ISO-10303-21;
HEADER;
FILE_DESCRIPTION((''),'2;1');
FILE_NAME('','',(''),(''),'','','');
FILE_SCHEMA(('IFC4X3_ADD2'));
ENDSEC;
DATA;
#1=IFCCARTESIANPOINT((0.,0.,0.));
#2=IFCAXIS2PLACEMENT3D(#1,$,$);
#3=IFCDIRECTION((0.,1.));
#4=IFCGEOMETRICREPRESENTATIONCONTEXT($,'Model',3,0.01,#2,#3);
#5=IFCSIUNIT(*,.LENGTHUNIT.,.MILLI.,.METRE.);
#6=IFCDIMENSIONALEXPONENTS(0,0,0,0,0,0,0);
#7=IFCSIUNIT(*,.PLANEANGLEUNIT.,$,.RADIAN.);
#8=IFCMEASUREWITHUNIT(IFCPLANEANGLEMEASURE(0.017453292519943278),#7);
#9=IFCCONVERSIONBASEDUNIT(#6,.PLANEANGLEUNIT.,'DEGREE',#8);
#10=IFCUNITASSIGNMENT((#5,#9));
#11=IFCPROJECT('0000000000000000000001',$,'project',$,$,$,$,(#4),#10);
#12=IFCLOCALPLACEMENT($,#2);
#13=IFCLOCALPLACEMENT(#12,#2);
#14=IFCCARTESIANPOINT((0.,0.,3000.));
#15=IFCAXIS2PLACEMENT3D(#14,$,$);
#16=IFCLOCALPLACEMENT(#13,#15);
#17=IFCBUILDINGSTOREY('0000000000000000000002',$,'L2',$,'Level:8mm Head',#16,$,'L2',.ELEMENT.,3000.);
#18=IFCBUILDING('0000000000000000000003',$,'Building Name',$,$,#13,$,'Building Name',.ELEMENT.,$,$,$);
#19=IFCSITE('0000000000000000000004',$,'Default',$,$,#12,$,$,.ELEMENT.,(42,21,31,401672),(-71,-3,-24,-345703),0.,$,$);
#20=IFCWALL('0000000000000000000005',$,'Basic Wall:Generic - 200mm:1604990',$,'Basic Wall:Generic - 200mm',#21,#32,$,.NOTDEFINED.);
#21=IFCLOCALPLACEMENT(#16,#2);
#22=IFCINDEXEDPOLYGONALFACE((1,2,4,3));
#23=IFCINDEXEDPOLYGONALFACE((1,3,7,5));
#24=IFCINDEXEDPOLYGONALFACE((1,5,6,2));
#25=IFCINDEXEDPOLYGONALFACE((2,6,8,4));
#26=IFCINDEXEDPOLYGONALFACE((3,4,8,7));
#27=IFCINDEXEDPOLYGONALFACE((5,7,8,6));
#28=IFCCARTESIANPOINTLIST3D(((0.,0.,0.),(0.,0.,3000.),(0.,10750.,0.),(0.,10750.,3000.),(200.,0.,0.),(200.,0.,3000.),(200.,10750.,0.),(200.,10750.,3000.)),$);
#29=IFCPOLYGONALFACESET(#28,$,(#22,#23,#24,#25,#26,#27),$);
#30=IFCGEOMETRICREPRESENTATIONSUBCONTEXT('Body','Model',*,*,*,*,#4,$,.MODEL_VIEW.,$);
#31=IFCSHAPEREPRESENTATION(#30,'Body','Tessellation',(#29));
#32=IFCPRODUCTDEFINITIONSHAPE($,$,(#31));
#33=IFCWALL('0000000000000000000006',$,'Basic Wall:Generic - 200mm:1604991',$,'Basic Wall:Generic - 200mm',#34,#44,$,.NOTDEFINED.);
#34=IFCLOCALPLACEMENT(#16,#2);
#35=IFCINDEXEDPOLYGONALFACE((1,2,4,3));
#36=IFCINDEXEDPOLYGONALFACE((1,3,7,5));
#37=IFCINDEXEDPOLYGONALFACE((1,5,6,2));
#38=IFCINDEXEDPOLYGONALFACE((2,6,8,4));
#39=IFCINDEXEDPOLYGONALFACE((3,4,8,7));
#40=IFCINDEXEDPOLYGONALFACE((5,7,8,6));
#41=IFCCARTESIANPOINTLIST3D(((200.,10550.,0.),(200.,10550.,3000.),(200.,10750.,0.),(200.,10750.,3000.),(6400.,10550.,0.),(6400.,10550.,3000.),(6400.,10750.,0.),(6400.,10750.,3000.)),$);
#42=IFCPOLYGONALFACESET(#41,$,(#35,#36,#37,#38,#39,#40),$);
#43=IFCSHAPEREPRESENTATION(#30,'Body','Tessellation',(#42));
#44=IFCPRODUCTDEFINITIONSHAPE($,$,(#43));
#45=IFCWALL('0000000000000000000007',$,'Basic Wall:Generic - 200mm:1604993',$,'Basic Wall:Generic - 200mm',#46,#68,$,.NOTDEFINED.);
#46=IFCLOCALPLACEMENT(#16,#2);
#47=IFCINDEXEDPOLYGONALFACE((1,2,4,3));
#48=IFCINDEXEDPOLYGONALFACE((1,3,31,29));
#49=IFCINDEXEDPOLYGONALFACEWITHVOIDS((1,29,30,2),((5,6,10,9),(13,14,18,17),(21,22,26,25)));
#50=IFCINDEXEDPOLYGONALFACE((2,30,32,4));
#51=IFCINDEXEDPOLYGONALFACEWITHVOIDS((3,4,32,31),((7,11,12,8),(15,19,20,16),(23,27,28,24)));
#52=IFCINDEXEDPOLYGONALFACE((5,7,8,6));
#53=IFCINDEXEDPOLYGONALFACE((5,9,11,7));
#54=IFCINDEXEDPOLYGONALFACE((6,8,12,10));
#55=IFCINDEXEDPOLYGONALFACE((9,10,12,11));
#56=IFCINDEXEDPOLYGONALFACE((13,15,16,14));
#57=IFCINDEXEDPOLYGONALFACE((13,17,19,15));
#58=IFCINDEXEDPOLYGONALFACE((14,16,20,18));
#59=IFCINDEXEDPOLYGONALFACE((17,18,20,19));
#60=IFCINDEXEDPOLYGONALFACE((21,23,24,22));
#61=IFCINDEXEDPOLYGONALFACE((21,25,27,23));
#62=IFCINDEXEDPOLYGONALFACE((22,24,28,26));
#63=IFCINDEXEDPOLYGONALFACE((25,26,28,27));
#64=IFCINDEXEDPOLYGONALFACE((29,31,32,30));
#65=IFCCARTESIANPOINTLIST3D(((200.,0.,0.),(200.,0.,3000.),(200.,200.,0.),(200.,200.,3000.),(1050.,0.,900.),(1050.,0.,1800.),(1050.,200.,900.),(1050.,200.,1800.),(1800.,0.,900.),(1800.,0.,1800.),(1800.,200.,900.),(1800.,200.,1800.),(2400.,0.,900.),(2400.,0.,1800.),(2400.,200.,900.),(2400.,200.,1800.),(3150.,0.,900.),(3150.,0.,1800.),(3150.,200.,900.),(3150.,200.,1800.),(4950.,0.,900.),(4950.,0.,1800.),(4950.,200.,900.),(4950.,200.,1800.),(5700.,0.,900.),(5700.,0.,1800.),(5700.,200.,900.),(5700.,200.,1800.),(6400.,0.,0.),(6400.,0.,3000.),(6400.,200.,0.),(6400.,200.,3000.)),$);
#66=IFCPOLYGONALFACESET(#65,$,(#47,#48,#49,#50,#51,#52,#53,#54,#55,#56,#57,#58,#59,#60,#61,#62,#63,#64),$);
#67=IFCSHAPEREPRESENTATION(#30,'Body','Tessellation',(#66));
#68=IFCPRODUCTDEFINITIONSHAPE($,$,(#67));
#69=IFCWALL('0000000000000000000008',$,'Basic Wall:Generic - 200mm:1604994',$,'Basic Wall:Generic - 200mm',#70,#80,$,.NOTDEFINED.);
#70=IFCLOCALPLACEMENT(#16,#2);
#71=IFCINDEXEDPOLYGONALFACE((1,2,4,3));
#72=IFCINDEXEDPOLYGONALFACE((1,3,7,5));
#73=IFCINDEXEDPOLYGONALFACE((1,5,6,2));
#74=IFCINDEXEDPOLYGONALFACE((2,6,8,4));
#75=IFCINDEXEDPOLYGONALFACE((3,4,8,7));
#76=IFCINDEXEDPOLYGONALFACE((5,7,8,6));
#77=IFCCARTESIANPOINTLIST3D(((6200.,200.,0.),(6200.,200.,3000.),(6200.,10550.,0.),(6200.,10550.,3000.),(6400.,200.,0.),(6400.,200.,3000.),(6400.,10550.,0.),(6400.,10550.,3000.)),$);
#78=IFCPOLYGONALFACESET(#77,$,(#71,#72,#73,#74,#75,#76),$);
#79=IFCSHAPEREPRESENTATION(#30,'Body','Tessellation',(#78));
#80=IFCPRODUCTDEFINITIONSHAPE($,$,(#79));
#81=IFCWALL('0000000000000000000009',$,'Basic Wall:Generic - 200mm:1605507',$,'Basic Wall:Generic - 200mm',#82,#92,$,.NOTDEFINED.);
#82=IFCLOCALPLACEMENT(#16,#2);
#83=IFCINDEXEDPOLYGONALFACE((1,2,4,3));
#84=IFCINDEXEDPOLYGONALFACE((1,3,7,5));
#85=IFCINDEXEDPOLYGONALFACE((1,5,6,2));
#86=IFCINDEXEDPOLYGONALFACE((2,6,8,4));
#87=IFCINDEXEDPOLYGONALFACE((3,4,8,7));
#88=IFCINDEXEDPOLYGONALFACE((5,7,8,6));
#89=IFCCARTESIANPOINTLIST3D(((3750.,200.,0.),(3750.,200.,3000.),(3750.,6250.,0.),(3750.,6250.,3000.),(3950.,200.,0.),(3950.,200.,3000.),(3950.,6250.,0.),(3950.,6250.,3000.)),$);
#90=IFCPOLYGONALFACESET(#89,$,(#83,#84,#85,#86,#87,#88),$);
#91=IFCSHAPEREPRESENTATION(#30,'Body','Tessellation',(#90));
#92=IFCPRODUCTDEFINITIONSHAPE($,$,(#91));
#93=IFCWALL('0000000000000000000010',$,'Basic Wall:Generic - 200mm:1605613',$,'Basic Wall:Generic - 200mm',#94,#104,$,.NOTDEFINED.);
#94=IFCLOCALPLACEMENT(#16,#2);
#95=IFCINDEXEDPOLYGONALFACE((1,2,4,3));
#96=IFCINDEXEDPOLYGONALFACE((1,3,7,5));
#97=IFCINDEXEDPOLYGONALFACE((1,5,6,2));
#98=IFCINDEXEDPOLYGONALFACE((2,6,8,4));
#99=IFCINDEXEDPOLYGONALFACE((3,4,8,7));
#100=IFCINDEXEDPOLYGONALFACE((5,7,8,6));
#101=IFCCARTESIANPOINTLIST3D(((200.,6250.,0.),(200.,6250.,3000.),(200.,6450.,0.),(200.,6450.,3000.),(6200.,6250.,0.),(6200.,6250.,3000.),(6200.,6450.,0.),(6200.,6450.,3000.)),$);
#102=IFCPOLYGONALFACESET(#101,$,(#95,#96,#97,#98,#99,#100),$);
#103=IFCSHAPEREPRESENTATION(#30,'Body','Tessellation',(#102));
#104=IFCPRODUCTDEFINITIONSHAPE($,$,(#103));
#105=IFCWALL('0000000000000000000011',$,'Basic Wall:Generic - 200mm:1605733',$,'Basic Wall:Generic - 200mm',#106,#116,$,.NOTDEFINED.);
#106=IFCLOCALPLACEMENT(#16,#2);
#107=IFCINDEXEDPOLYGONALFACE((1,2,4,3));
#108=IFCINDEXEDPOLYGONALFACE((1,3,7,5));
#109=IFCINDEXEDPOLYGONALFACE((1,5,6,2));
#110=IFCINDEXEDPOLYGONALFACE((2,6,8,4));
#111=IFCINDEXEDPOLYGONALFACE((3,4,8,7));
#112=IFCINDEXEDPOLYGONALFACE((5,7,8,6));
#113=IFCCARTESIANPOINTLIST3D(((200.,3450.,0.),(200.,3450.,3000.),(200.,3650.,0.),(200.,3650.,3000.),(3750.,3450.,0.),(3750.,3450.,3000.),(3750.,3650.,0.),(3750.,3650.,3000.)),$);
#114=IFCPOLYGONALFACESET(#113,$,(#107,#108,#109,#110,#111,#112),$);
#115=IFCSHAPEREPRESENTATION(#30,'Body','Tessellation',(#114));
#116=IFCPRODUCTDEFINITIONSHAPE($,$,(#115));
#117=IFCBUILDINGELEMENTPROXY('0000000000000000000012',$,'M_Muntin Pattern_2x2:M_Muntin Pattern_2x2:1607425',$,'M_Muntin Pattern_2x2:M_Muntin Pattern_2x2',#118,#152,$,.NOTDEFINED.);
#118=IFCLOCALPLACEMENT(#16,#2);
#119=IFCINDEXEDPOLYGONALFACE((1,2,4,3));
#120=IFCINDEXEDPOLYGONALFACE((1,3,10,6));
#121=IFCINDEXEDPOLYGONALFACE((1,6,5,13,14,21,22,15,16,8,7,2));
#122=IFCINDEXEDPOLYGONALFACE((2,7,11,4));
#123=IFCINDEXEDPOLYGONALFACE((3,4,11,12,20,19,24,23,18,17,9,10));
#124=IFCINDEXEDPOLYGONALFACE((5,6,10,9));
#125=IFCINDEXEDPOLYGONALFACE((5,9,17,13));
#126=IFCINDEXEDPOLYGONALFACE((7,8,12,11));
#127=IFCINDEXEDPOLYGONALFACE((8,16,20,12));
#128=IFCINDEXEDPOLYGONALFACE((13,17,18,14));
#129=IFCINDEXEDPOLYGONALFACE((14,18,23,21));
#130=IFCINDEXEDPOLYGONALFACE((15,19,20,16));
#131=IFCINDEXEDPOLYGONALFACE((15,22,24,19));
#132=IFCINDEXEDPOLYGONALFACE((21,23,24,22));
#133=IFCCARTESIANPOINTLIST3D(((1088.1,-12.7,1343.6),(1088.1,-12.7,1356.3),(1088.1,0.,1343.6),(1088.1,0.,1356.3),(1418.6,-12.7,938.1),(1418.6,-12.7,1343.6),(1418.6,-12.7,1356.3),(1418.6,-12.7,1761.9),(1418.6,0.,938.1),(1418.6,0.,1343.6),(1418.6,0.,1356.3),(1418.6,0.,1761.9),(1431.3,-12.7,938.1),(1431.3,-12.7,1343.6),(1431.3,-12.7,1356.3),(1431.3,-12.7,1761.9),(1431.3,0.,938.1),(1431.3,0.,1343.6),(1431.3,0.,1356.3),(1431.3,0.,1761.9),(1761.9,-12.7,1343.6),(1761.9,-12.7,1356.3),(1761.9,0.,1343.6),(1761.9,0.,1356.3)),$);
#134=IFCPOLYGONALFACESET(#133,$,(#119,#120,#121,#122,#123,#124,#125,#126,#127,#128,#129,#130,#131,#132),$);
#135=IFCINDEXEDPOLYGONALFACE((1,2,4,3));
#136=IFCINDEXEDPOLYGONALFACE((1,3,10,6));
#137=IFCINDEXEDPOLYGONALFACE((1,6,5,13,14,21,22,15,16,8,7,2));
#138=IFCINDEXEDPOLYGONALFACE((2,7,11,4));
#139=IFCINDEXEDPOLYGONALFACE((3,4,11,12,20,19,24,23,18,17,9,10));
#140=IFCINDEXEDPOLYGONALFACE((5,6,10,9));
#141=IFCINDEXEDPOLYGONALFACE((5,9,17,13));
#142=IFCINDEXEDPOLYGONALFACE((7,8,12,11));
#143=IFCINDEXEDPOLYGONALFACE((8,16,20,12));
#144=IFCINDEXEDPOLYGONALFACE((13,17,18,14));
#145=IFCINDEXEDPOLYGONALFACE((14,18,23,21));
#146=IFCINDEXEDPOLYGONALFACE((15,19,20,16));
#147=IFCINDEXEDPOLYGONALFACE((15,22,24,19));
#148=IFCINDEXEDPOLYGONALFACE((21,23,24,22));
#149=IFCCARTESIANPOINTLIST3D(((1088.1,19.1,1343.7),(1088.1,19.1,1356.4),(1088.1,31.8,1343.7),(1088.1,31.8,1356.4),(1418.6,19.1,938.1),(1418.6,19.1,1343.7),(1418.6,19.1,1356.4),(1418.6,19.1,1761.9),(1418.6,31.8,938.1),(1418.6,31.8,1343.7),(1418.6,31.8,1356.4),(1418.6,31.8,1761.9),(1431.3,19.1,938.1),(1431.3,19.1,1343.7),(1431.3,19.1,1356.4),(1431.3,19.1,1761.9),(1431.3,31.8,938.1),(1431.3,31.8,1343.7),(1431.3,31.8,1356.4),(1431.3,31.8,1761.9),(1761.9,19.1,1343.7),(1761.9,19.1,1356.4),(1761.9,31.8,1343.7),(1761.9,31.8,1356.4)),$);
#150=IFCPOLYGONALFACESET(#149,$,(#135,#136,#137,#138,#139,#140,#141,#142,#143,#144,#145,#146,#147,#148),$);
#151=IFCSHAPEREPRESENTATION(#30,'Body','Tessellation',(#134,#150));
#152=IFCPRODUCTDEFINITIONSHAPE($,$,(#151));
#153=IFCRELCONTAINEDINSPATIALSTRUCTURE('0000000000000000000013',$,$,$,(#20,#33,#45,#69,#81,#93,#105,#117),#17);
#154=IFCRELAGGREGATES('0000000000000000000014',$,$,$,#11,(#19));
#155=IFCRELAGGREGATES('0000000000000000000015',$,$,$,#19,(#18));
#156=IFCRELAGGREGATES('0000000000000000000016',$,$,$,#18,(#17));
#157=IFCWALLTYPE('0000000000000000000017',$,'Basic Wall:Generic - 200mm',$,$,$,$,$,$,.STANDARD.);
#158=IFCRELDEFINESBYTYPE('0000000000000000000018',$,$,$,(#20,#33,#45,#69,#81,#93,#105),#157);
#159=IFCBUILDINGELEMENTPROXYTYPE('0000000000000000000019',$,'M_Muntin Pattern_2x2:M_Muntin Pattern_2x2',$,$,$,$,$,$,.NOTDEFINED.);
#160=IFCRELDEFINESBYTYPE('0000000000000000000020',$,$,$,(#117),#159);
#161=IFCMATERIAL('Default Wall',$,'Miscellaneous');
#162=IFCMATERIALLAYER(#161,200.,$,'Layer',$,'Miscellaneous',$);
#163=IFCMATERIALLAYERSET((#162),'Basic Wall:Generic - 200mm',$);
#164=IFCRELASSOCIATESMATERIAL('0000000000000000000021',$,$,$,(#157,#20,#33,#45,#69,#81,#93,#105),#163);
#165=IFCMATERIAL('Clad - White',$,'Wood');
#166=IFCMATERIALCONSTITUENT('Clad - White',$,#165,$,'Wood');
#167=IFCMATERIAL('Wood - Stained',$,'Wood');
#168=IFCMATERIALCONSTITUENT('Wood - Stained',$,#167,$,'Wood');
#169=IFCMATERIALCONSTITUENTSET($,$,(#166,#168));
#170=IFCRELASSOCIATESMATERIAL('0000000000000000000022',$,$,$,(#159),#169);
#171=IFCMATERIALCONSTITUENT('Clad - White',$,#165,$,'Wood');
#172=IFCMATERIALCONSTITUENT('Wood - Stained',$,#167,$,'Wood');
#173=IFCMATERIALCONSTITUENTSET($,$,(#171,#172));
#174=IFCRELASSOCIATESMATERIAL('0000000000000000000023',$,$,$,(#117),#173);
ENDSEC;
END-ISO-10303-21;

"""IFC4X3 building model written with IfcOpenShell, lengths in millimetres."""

from ifc_helpers import new_model, entity, si_unit, converted_unit, direction, frame, frame_2d, origin, place, context, subcontext, project, spatial, polyline, rectangle, outline, extrude, source, transform, mapped, material, layer, layer_set, constituent, constituent_set, type_object, type_shapes, element, save


model = new_model("IFC4X3")

# Units and contexts
model_context = context("Model", 3, precision=0.01, world=origin(), true_north=direction((0.0, 1.0)))
body_context = subcontext(model_context, "Body", "Model", "MODEL_VIEW")
ifc_project = project(units=[si_unit("LENGTHUNIT", "METRE", prefix="MILLI"), converted_unit("PLANEANGLEUNIT", "DEGREE", entity("IfcPlaneAngleMeasure", 0.017453292519943278), si_unit("PLANEANGLEUNIT", "RADIAN"), dimensions=[0, 0, 0, 0, 0, 0, 0])], contexts=[model_context])

# Site, building, storey
site_placement = place(None, origin())
site = spatial("IfcSite", under=ifc_project, at=site_placement, Name="Default", CompositionType="ELEMENT", RefLatitude=(42, 21, 31, 401672), RefLongitude=(-71, -3, -24, -345703), RefElevation=0.0)
building_placement = place(site_placement, origin())
building = spatial("IfcBuilding", under=site, at=building_placement, Name="Building Name", LongName="Building Name", CompositionType="ELEMENT")
storey_placement = place(building_placement, frame((0.0, 0.0, 3000.0)))
storey = spatial("IfcBuildingStorey", under=building, at=storey_placement, Name="L2", ObjectType="Level:8mm Head", LongName="L2", CompositionType="ELEMENT", Elevation=3000.0)

# Walls
ifc_material_1 = material(Name="Default Wall", Category="Miscellaneous")
ifc_layer = layer(ifc_material_1, 200.0, Name="Layer", Category="Miscellaneous")
ifc_layer_set = layer_set([ifc_layer], Name="Basic Wall:Generic - 200mm")
wall_type = type_object("IfcWallType", Name="Basic Wall:Generic - 200mm", PredefinedType="STANDARD", material=ifc_layer_set)
wall_1_placement = place(storey_placement, frame((100.0, 0.0, 0.0), z_axis=(0.0, 0.0, 1.0), x_axis=(0.0, 1.0, 0.0)))
element("IfcWall", 1, at=wall_1_placement, inside=storey, type_object=wall_type, material=ifc_layer_set, Name="Basic Wall:Generic - 200mm:1604990", ObjectType="Basic Wall:Generic - 200mm", PredefinedType="NOTDEFINED", context=body_context, shape_type="SweptSolid", body=[
    extrude(rectangle(XDim=10750.0, YDim=200.0, at=frame_2d((5375.0, 0.0), x_axis=(-1.0, 0.0))), origin(), (0.0, 0.0, 1.0), 3000.0),
])
wall_2_placement = place(storey_placement, frame((200.0, 10650.0, 0.0)))
element("IfcWall", 2, at=wall_2_placement, inside=storey, type_object=wall_type, material=ifc_layer_set, Name="Basic Wall:Generic - 200mm:1604991", ObjectType="Basic Wall:Generic - 200mm", PredefinedType="NOTDEFINED", context=body_context, shape_type="SweptSolid", body=[
    extrude(rectangle(XDim=6200.0, YDim=200.0, at=frame_2d((3100.0, 0.0), x_axis=(-1.0, 0.0))), origin(), (0.0, 0.0, 1.0), 3000.0),
])

# Wall, openings
wall_3_placement = place(storey_placement, frame((6400.0, 100.0, 0.0), z_axis=(0.0, 0.0, 1.0), x_axis=(-1.0, 0.0, 0.0)))
wall_3 = element("IfcWall", 3, at=wall_3_placement, inside=storey, type_object=wall_type, material=ifc_layer_set, Name="Basic Wall:Generic - 200mm:1604993", ObjectType="Basic Wall:Generic - 200mm", PredefinedType="NOTDEFINED", context=body_context, shape_type="SweptSolid", body=[
    extrude(rectangle(XDim=6200.0, YDim=200.0, at=frame_2d((3100.0, 0.0), x_axis=(-1.0, 0.0))), origin(), (0.0, 0.0, 1.0), 3000.0),
])
opening_1_placement = place(wall_3_placement, frame((4600.0, -100.0, 900.0)))
element("IfcOpeningElement", 4, at=opening_1_placement, cuts=wall_3, PredefinedType="OPENING", context=body_context, shape_type="SweptSolid", body=[
    extrude(rectangle(XDim=900.0, YDim=750.0, at=frame_2d((450.0, 375.0), x_axis=(-1.0, 0.0))), frame((0.0, 0.0, 0.0), z_axis=(0.0, 1.0, 0.0), x_axis=(0.0, 0.0, 1.0)), (0.0, 0.0, 1.0), 200.0),
])
opening_2_placement = place(wall_3_placement, frame((3250.0, -100.0, 900.0)))
element("IfcOpeningElement", 5, at=opening_2_placement, cuts=wall_3, PredefinedType="OPENING", context=body_context, shape_type="SweptSolid", body=[
    extrude(rectangle(XDim=900.0, YDim=750.0, at=frame_2d((450.0, 375.0), x_axis=(-1.0, 0.0))), frame((0.0, 0.0, 0.0), z_axis=(0.0, 1.0, 0.0), x_axis=(0.0, 0.0, 1.0)), (0.0, 0.0, 1.0), 200.0),
])
opening_3_placement = place(wall_3_placement, frame((700.0, -100.0, 900.0)))
element("IfcOpeningElement", 6, at=opening_3_placement, cuts=wall_3, PredefinedType="OPENING", context=body_context, shape_type="SweptSolid", body=[
    extrude(rectangle(XDim=900.0, YDim=750.0, at=frame_2d((450.0, 375.0), x_axis=(-1.0, 0.0))), frame((0.0, 0.0, 0.0), z_axis=(0.0, 1.0, 0.0), x_axis=(0.0, 0.0, 1.0)), (0.0, 0.0, 1.0), 200.0),
])

# Walls
wall_4_placement = place(storey_placement, frame((6300.0, 200.0, 0.0), z_axis=(0.0, 0.0, 1.0), x_axis=(0.0, 1.0, 0.0)))
element("IfcWall", 7, at=wall_4_placement, inside=storey, type_object=wall_type, material=ifc_layer_set, Name="Basic Wall:Generic - 200mm:1604994", ObjectType="Basic Wall:Generic - 200mm", PredefinedType="NOTDEFINED", context=body_context, shape_type="SweptSolid", body=[
    extrude(rectangle(XDim=10350.0, YDim=200.0, at=frame_2d((5175.0, 0.0), x_axis=(-1.0, 0.0))), origin(), (0.0, 0.0, 1.0), 3000.0),
])
wall_5_placement = place(storey_placement, frame((3850.0, 200.0, 0.0), z_axis=(0.0, 0.0, 1.0), x_axis=(0.0, 1.0, 0.0)))
element("IfcWall", 8, at=wall_5_placement, inside=storey, type_object=wall_type, material=ifc_layer_set, Name="Basic Wall:Generic - 200mm:1605507", ObjectType="Basic Wall:Generic - 200mm", PredefinedType="NOTDEFINED", context=body_context, shape_type="SweptSolid", body=[
    extrude(rectangle(XDim=6050.0, YDim=200.0, at=frame_2d((3025.0, 0.0), x_axis=(-1.0, 0.0))), origin(), (0.0, 0.0, 1.0), 3000.0),
])
wall_6_placement = place(storey_placement, frame((6200.0, 6350.0, 0.0), z_axis=(0.0, 0.0, 1.0), x_axis=(-1.0, 0.0, 0.0)))
element("IfcWall", 9, at=wall_6_placement, inside=storey, type_object=wall_type, material=ifc_layer_set, Name="Basic Wall:Generic - 200mm:1605613", ObjectType="Basic Wall:Generic - 200mm", PredefinedType="NOTDEFINED", context=body_context, shape_type="SweptSolid", body=[
    extrude(rectangle(XDim=6000.0, YDim=200.0, at=frame_2d((3000.0, 0.0), x_axis=(-1.0, 0.0))), origin(), (0.0, 0.0, 1.0), 3000.0),
])
wall_7_placement = place(storey_placement, frame((3750.0, 3550.0, 0.0), z_axis=(0.0, 0.0, 1.0), x_axis=(-1.0, 0.0, 0.0)))
element("IfcWall", 10, at=wall_7_placement, inside=storey, type_object=wall_type, material=ifc_layer_set, Name="Basic Wall:Generic - 200mm:1605733", ObjectType="Basic Wall:Generic - 200mm", PredefinedType="NOTDEFINED", context=body_context, shape_type="SweptSolid", body=[
    extrude(rectangle(XDim=3550.0, YDim=200.0, at=frame_2d((1775.0, 0.0), x_axis=(-1.0, 0.0))), origin(), (0.0, 0.0, 1.0), 3000.0),
])

# Building element proxy
ifc_material_2 = material(Name="Clad - White", Category="Wood")
ifc_constituent_1 = constituent(ifc_material_2, Name="Clad - White", Category="Wood")
ifc_material_3 = material(Name="Wood - Stained", Category="Wood")
ifc_constituent_2 = constituent(ifc_material_3, Name="Wood - Stained", Category="Wood")
ifc_constituent_set_1 = constituent_set(constituents=[ifc_constituent_1, ifc_constituent_2])
ifc_constituent_3 = constituent(ifc_material_2, Name="Clad - White", Category="Wood")
ifc_constituent_4 = constituent(ifc_material_3, Name="Wood - Stained", Category="Wood")
ifc_constituent_set_2 = constituent_set(constituents=[ifc_constituent_3, ifc_constituent_4])
building_element_proxy_type_1 = type_object("IfcBuildingElementProxyType", Name="M_Muntin Pattern_2x2:M_Muntin Pattern_2x2", PredefinedType="NOTDEFINED", material=ifc_constituent_set_2)
shared_shape_1 = source(origin(), body_context, "Body", "SweptSolid", [
    extrude(outline(polyline([(6.4, -6.4), (411.9, -6.4), (411.9, 6.3), (6.4, 6.3), (6.4, 336.9), (-6.3, 336.9), (-6.3, 6.3), (-411.9, 6.3), (-411.9, -6.4), (-6.3, -6.4), (-6.3, -336.9), (6.4, -336.9), (6.4, -6.4)])), frame((0.0, -22.2, 411.9), z_axis=(0.0, 1.0, 0.0), x_axis=(0.0, 0.0, 1.0)), (0.0, 0.0, 1.0), 12.7),
    extrude(outline(polyline([(6.4, -6.4), (411.9, -6.4), (411.9, 6.3), (6.4, 6.3), (6.4, 336.9), (-6.3, 336.9), (-6.3, 6.3), (-411.9, 6.3), (-411.9, -6.4), (-6.3, -6.4), (-6.3, -336.9), (6.4, -336.9), (6.4, -6.4)])), frame((0.0, 9.5, 411.9), z_axis=(0.0, 1.0, 0.0), x_axis=(0.0, 0.0, 1.0)), (0.0, 0.0, 1.0), 12.7),
])
type_shapes(building_element_proxy_type_1, [shared_shape_1])
proxy_1_placement = place(storey_placement, frame((1425.0, 9.5, 938.1)))
element("IfcBuildingElementProxy", 11, at=proxy_1_placement, inside=storey, type_object=building_element_proxy_type_1, material=ifc_constituent_set_1, Name="M_Muntin Pattern_2x2:M_Muntin Pattern_2x2:1607425", ObjectType="M_Muntin Pattern_2x2:M_Muntin Pattern_2x2", PredefinedType="NOTDEFINED", context=body_context, shape_type="MappedRepresentation", body=[
    mapped(shared_shape_1, transform((0.0, 0.0, 0.0), scale=1.0)),
])

save(model, "model.ifc")
